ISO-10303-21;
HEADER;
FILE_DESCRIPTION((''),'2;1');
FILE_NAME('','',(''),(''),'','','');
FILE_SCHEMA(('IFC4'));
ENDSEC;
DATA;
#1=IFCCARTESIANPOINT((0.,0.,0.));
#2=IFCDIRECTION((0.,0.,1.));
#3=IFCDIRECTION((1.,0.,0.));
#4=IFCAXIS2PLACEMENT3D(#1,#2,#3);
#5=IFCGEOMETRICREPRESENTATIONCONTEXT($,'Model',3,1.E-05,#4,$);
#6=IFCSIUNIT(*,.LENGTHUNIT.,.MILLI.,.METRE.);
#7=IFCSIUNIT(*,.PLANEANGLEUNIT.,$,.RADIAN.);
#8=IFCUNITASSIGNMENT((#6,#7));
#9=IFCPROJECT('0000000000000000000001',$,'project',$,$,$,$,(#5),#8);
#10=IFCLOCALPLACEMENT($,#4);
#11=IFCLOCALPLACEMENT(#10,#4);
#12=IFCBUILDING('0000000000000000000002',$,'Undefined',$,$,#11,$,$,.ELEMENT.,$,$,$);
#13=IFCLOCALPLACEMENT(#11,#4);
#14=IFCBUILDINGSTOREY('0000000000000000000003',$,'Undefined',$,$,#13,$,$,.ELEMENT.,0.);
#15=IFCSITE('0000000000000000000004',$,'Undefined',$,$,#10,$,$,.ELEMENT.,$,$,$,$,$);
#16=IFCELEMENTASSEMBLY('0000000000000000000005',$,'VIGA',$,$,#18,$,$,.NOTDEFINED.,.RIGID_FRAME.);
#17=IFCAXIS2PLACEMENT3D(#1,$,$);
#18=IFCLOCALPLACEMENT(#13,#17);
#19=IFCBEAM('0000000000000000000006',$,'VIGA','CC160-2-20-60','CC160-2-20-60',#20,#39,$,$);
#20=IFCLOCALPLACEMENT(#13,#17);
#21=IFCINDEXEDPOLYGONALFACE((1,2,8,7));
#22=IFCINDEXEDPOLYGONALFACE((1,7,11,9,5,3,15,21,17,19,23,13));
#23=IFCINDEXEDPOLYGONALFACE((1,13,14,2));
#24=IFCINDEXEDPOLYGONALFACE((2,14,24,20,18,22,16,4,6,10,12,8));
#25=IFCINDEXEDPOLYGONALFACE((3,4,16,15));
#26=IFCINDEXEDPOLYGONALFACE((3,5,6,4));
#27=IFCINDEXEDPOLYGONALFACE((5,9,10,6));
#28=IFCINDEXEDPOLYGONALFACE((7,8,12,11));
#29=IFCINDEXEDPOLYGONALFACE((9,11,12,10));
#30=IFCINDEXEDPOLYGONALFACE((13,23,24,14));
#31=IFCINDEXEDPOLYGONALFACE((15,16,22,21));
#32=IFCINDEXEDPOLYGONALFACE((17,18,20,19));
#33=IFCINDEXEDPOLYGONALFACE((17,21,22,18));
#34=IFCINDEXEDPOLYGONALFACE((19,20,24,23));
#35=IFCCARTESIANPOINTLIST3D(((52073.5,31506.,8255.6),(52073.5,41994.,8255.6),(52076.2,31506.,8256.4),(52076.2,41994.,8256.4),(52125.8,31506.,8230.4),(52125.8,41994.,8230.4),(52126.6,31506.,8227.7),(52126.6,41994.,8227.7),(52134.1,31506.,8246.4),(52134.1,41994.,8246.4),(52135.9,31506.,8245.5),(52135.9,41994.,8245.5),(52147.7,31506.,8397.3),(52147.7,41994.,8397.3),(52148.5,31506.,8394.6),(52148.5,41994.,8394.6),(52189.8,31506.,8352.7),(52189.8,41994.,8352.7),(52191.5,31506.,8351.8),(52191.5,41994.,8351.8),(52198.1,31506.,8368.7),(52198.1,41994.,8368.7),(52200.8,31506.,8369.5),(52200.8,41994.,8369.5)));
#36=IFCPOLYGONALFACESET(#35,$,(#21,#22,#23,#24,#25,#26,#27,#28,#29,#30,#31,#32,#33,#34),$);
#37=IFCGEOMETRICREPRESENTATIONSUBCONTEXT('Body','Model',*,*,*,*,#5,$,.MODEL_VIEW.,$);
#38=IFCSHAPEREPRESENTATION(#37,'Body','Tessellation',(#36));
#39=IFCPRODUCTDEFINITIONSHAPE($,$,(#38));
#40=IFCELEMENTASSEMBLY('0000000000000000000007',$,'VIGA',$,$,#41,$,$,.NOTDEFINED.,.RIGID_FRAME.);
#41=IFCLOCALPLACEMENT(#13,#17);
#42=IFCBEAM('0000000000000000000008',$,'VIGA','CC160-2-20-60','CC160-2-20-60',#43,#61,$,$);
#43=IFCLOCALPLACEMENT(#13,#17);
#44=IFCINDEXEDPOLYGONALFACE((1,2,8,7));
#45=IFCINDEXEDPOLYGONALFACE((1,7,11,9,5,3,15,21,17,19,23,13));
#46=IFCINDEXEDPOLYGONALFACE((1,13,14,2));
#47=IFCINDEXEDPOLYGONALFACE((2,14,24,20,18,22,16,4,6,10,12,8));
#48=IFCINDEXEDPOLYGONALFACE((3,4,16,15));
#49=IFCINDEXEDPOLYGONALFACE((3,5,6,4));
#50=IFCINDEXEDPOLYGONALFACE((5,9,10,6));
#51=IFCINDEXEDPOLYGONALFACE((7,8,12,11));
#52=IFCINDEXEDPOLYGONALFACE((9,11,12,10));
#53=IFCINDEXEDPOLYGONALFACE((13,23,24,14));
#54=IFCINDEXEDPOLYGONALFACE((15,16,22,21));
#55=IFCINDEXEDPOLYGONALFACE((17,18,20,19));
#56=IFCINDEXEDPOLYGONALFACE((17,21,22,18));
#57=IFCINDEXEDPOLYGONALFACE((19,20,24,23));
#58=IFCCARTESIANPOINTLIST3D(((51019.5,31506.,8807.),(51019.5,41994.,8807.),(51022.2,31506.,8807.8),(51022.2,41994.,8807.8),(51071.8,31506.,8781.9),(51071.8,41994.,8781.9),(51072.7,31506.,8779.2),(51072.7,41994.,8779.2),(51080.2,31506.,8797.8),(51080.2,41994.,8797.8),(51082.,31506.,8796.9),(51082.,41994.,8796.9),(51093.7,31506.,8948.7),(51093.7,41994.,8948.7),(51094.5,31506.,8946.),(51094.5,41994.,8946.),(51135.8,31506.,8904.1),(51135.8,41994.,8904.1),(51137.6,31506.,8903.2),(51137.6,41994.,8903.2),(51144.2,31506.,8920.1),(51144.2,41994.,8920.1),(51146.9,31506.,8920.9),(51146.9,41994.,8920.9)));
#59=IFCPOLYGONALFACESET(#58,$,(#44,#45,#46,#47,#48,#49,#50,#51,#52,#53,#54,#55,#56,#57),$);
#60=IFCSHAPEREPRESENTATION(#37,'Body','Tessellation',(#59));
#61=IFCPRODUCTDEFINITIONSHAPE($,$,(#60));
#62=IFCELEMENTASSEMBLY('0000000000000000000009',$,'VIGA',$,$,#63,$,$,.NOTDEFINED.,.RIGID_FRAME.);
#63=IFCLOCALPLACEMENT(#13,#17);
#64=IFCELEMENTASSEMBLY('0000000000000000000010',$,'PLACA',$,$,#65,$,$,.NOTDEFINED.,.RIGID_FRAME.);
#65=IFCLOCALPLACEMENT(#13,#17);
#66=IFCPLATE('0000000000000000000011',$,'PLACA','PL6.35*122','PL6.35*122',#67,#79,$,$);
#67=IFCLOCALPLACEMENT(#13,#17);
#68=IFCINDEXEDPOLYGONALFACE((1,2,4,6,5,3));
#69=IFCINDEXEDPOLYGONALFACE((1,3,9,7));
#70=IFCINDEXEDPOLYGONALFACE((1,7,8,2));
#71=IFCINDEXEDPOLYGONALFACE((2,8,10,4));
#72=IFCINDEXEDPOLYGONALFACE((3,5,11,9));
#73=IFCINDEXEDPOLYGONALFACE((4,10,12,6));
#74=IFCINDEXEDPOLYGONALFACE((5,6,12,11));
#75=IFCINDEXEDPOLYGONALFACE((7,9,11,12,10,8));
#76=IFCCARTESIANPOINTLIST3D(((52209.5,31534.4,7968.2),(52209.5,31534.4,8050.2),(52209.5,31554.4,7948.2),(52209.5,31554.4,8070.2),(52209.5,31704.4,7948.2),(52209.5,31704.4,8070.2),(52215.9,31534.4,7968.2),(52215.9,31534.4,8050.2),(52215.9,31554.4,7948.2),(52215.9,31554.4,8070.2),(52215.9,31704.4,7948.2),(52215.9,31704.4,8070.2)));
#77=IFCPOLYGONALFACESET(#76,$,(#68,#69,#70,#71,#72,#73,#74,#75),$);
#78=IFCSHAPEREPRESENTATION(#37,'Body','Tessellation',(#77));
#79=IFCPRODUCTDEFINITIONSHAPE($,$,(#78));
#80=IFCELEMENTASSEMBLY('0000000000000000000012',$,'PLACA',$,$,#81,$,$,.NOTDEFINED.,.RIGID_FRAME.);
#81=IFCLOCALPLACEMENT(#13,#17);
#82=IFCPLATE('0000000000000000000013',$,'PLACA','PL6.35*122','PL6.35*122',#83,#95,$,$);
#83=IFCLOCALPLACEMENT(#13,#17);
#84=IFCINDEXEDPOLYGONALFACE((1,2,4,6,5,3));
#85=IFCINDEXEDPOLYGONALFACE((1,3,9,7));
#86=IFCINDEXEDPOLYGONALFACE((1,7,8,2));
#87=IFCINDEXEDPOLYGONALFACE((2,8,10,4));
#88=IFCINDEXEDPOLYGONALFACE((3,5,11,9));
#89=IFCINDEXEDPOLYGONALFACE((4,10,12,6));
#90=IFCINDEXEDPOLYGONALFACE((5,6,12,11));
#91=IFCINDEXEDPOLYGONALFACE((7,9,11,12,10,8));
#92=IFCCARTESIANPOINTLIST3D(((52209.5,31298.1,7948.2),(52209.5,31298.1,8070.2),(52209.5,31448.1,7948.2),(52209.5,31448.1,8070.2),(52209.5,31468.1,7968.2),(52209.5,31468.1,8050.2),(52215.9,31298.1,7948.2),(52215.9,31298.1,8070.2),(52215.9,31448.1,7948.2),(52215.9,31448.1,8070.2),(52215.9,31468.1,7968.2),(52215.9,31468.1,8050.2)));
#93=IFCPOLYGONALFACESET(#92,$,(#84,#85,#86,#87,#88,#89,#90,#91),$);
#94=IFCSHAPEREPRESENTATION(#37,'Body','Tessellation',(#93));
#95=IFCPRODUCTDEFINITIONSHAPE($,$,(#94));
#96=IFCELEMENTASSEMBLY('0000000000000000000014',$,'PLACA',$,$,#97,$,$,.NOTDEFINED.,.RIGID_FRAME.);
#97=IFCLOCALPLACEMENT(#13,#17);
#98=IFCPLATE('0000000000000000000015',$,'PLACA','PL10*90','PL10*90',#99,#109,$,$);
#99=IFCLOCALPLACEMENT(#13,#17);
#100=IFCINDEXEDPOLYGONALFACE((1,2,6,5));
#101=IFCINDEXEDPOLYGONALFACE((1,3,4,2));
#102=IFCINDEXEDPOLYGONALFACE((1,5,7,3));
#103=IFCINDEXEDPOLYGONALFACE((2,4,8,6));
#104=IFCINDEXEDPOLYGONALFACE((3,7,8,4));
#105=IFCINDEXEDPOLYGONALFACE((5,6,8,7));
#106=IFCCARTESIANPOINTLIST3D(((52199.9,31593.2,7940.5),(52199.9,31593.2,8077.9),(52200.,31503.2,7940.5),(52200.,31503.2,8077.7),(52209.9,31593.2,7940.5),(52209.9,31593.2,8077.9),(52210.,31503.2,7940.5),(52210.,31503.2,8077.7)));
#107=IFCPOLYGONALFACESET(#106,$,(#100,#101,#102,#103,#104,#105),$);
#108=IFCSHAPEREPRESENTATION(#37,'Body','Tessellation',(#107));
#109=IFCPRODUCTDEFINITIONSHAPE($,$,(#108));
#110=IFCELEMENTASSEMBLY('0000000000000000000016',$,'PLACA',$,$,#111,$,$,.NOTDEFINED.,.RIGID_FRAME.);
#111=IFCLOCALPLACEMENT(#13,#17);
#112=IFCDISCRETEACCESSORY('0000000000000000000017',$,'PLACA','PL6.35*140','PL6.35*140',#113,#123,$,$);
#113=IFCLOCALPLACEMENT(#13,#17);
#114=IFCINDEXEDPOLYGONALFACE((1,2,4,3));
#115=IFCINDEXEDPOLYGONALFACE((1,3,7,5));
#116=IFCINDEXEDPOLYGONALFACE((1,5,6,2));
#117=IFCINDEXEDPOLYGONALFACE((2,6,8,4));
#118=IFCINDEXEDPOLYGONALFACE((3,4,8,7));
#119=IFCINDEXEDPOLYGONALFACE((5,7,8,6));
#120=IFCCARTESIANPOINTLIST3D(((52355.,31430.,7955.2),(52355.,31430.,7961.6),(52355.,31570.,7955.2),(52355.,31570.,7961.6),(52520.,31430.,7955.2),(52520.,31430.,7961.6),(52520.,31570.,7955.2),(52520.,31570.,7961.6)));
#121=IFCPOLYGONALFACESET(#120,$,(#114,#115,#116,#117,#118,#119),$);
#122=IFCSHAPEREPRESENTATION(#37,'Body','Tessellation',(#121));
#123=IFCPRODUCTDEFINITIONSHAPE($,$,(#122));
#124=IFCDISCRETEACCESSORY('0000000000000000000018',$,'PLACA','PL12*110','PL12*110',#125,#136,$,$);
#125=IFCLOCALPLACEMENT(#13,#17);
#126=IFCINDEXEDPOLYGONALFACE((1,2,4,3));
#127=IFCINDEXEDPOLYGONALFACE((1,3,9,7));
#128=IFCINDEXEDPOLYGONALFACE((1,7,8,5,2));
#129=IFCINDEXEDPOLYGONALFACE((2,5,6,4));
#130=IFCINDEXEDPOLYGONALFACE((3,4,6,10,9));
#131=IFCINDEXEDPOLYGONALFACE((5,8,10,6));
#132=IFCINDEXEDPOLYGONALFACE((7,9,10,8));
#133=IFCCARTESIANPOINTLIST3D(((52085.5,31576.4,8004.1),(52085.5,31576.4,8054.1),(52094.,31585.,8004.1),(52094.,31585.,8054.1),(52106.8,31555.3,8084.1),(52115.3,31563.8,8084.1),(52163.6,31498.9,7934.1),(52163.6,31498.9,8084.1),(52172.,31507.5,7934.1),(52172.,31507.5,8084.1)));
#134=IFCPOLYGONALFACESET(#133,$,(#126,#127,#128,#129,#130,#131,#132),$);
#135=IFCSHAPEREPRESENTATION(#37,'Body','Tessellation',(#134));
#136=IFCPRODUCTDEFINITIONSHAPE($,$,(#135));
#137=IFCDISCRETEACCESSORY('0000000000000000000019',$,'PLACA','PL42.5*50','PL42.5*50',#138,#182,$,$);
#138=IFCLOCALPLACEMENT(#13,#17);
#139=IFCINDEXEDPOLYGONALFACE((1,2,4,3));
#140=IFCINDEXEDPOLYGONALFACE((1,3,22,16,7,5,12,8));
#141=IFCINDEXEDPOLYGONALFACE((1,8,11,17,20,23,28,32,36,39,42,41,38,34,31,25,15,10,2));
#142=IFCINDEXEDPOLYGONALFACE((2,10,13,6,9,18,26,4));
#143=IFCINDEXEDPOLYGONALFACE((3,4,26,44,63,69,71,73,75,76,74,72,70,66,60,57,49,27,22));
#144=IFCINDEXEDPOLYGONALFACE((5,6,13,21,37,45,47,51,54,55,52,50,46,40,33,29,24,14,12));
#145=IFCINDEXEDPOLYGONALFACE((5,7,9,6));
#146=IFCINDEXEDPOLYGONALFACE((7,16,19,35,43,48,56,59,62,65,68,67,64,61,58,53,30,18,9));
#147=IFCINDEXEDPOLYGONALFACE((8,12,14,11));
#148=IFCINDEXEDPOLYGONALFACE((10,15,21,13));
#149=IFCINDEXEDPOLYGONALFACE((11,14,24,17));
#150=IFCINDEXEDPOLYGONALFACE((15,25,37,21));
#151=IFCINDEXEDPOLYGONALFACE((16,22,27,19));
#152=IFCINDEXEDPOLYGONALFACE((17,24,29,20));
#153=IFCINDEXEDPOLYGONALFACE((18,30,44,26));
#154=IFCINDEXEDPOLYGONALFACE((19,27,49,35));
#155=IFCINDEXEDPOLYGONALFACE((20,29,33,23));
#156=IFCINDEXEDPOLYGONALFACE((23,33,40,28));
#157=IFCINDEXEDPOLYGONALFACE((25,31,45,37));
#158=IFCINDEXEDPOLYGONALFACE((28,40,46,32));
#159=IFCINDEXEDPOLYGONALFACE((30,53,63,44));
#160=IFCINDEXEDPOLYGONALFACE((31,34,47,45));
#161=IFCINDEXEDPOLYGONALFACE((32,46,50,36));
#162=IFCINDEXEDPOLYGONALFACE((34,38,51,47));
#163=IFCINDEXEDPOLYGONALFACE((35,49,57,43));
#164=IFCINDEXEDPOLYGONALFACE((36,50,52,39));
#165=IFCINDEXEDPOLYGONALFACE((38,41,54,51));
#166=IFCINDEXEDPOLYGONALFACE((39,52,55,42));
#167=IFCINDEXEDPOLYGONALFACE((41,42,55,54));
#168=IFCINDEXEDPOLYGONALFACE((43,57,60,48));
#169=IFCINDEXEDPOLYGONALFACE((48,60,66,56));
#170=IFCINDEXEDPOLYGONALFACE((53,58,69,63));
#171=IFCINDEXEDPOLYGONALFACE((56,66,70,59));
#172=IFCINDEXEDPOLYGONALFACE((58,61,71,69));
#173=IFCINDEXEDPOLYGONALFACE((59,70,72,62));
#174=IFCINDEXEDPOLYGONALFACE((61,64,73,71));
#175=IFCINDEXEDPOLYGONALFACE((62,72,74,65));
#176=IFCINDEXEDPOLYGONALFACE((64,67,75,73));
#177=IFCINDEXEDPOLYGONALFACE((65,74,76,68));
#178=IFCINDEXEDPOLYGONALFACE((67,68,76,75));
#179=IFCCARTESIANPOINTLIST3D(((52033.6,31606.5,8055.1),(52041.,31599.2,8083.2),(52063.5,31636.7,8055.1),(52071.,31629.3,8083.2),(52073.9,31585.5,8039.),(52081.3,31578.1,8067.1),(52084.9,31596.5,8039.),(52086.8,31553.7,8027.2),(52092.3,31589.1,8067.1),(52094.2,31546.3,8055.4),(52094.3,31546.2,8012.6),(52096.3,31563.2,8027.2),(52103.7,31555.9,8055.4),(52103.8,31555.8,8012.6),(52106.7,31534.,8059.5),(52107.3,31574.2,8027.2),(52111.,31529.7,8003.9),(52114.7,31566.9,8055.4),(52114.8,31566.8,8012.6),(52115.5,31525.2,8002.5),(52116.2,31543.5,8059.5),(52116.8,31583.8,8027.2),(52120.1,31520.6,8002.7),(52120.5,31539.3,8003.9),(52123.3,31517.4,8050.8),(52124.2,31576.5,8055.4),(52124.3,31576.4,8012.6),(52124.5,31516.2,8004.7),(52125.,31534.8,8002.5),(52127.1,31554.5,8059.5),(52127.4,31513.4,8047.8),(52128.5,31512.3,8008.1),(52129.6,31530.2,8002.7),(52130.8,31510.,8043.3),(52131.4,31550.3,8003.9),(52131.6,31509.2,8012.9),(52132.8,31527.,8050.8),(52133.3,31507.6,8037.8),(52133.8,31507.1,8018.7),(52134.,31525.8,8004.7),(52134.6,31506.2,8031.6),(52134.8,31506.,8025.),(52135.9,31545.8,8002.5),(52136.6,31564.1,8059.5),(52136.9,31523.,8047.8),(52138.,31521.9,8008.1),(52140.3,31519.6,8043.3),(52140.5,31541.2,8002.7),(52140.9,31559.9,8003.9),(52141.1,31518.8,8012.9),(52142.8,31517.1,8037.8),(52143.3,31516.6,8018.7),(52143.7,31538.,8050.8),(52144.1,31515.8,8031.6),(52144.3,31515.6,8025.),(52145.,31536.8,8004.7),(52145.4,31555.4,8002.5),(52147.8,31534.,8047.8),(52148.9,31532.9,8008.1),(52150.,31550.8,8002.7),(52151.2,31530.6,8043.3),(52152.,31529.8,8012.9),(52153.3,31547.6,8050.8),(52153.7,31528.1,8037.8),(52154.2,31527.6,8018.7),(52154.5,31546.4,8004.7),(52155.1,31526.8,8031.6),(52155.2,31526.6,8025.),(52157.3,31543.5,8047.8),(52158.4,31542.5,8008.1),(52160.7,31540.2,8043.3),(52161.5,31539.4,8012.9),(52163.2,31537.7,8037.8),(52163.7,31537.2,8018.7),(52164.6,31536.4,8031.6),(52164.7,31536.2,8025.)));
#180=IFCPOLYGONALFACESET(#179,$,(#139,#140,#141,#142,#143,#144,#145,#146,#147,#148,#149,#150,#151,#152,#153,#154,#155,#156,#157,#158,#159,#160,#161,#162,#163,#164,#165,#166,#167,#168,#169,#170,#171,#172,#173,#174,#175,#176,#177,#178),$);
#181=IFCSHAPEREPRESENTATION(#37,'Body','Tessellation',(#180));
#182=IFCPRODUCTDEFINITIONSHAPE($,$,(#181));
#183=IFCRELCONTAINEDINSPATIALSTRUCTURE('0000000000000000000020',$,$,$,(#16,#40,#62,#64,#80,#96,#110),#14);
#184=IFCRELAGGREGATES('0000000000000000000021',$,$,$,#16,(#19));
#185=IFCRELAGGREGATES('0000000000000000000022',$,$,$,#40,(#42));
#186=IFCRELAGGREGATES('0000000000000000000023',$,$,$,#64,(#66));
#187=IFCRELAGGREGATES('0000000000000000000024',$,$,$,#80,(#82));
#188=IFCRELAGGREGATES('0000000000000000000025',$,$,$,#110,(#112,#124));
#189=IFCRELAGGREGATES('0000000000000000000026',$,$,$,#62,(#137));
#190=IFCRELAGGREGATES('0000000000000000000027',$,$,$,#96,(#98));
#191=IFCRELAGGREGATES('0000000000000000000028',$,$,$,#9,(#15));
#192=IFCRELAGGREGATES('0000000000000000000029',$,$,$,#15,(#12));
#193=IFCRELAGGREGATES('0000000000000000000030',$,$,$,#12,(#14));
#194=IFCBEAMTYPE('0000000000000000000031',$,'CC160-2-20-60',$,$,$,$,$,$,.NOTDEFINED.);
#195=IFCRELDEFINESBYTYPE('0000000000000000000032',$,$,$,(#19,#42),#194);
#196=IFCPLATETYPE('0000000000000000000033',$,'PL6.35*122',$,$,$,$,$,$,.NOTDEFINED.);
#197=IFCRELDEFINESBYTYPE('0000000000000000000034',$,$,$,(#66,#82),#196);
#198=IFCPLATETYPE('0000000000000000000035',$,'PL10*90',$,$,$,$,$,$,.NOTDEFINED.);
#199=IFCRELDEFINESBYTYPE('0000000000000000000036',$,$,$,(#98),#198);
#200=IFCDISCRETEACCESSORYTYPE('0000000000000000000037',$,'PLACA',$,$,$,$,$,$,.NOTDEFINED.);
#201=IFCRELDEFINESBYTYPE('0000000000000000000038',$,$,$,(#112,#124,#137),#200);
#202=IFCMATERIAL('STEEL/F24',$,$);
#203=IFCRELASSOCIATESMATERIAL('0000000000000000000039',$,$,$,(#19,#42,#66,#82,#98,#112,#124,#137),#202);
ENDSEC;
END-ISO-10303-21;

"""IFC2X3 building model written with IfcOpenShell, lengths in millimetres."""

from ifc_helpers import new_model, si_unit, frame, origin_with_axes, origin_2d_with_axis, place, context, subcontext, project, spatial, polyline, rectangle, c_section, outline, extrude, boolean, clip, halfspace, material, type_object, element, aggregate, save


model = new_model("IFC2X3")

# Units and contexts
model_context = context("Model", 3, precision=1e-05, world=origin_with_axes())
body_context = subcontext(model_context, "Body", "Model", "MODEL_VIEW")
ifc_project = project(units=[si_unit("LENGTHUNIT", "METRE", prefix="MILLI"), si_unit("PLANEANGLEUNIT", "RADIAN")], contexts=[model_context])

# Site, building, storey
site_placement = place(None, origin_with_axes())
site = spatial("IfcSite", under=ifc_project, at=site_placement, Name="Undefined", CompositionType="ELEMENT")
building_placement = place(site_placement, origin_with_axes())
building = spatial("IfcBuilding", under=site, at=building_placement, Name="Undefined", CompositionType="ELEMENT")
storey_placement = place(building_placement, origin_with_axes())
storey = spatial("IfcBuildingStorey", under=building, at=storey_placement, Name="Undefined", CompositionType="ELEMENT", Elevation=0.0)

# Element assemblies, beams
ifc_material_1 = material(Name="STEEL/F24")
assembly_1_placement = place(storey_placement, origin_with_axes())
assembly_1 = element("IfcElementAssembly", 1, at=assembly_1_placement, inside=storey, Name="VIGA", AssemblyPlace="NOTDEFINED", PredefinedType="RIGID_FRAME")
beam_type_1 = type_object("IfcBeamType", Name="CC160-2-20-60", PredefinedType="NOTDEFINED")
beam_1_placement = place(assembly_1_placement, frame((52137.1, 31500.0, 8312.5), z_axis=(0.463605, 0.0, 0.886042), x_axis=(0.0, 1.0, 0.0)))
beam_1 = element("IfcBeam", 2, at=beam_1_placement, type_object=beam_type_1, material=ifc_material_1, Name="VIGA", Description="CC160-2-20-60", ObjectType="CC160-2-20-60", context=body_context, shape_type="Clipping", body=[
    clip(clip(extrude(c_section(Depth=160.0, Width=60.0, WallThickness=2.0, Girth=20.0, at=origin_2d_with_axis()), frame((10500.0, 0.0, 0.0), z_axis=(-1.0, 0.0, 0.0), x_axis=(0.0, -1.0, 0.0)), (0.0, 0.0, 1.0), 10500.0), halfspace(frame((10494.0, 30.0, 80.0), z_axis=(1.0, 0.0, 0.000029), x_axis=(0.000029, 0.0, -1.0)), False)), halfspace(frame((6.0, -30.0, 80.0), z_axis=(-1.0, 0.0, -0.000029), x_axis=(0.000029, 0.0, -1.0)), False)),
])
aggregate(assembly_1, [beam_1])
assembly_2_placement = place(storey_placement, origin_with_axes())
assembly_2 = element("IfcElementAssembly", 3, at=assembly_2_placement, inside=storey, Name="VIGA", AssemblyPlace="NOTDEFINED", PredefinedType="RIGID_FRAME")
beam_2_placement = place(assembly_2_placement, frame((51083.2, 31500.0, 8864.0), z_axis=(0.463605, 0.0, 0.886042), x_axis=(0.0, 1.0, 0.0)))
beam_2 = element("IfcBeam", 4, at=beam_2_placement, type_object=beam_type_1, material=ifc_material_1, Name="VIGA", Description="CC160-2-20-60", ObjectType="CC160-2-20-60", context=body_context, shape_type="Clipping", body=[
    clip(clip(extrude(c_section(Depth=160.0, Width=60.0, WallThickness=2.0, Girth=20.0, at=origin_2d_with_axis()), frame((10500.0, 0.0, 0.0), z_axis=(-1.0, 0.0, 0.0), x_axis=(0.0, -1.0, 0.0)), (0.0, 0.0, 1.0), 10500.0), halfspace(frame((10494.0, 30.0, 80.0), z_axis=(1.0, 0.0, 0.000029), x_axis=(0.000029, 0.0, -1.0)), False)), halfspace(frame((6.0, -30.0, 80.0), z_axis=(-1.0, 0.0, -0.000029), x_axis=(0.000029, 0.0, -1.0)), False)),
])
aggregate(assembly_2, [beam_2])
assembly_3_placement = place(storey_placement, origin_with_axes())
assembly_3 = element("IfcElementAssembly", 5, at=assembly_3_placement, inside=storey, Name="VIGA", AssemblyPlace="NOTDEFINED", PredefinedType="RIGID_FRAME")

# Element assemblies, plates
assembly_4_placement = place(storey_placement, origin_with_axes())
assembly_4 = element("IfcElementAssembly", 6, at=assembly_4_placement, inside=storey, Name="PLACA", AssemblyPlace="NOTDEFINED", PredefinedType="RIGID_FRAME")
plate_type_1 = type_object("IfcPlateType", Name="PL6.35*122", PredefinedType="NOTDEFINED")
plate_1_placement = place(assembly_4_placement, frame((52212.7, 31534.4, 8070.2), z_axis=(-1.0, 0.0, 0.0), x_axis=(0.0, 1.0, 0.0)))
plate_1 = element("IfcPlate", 7, at=plate_1_placement, type_object=plate_type_1, material=ifc_material_1, Name="PLACA", Description="PL6.35*122", ObjectType="PL6.35*122", context=body_context, shape_type="SweptSolid", body=[
    extrude(outline(polyline([(0.0, 20.0), (20.0, 0.0), (170.0, 0.0), (170.0, 122.0), (20.0, 122.0), (0.0, 102.0), (0.0, 20.0)])), frame((0.0, 0.0, -3.2), z_axis=(0.0, 0.0, 1.0), x_axis=(1.0, 0.0, 0.0)), (0.0, 0.0, 1.0), 6.4),
])
aggregate(assembly_4, [plate_1])
assembly_5_placement = place(storey_placement, origin_with_axes())
assembly_5 = element("IfcElementAssembly", 8, at=assembly_5_placement, inside=storey, Name="PLACA", AssemblyPlace="NOTDEFINED", PredefinedType="RIGID_FRAME")
plate_2_placement = place(assembly_5_placement, frame((52212.7, 31468.1, 8070.2), z_axis=(1.0, 0.0, 0.0), x_axis=(0.0, -1.0, 0.0)))
plate_2 = element("IfcPlate", 9, at=plate_2_placement, type_object=plate_type_1, material=ifc_material_1, Name="PLACA", Description="PL6.35*122", ObjectType="PL6.35*122", context=body_context, shape_type="SweptSolid", body=[
    extrude(outline(polyline([(0.0, 20.0), (20.0, 0.0), (170.0, 0.0), (170.0, 122.0), (20.0, 122.0), (0.0, 102.0), (0.0, 20.0)])), frame((0.0, 0.0, -3.2), z_axis=(0.0, 0.0, 1.0), x_axis=(1.0, 0.0, 0.0)), (0.0, 0.0, 1.0), 6.4),
])
aggregate(assembly_5, [plate_2])
assembly_6_placement = place(storey_placement, origin_with_axes())
assembly_6 = element("IfcElementAssembly", 10, at=assembly_6_placement, inside=storey, Name="PLACA", AssemblyPlace="NOTDEFINED", PredefinedType="RIGID_FRAME")
plate_type_2 = type_object("IfcPlateType", Name="PL10*90", PredefinedType="NOTDEFINED")
plate_3_placement = place(assembly_6_placement, frame((52204.9, 31593.2, 7940.5), z_axis=(-1.0, -0.000594, -0.000001), x_axis=(0.000594, -1.0, 0.000002)))
plate_3 = element("IfcPlate", 11, at=plate_3_placement, type_object=plate_type_2, material=ifc_material_1, Name="PLACA", Description="PL10*90", ObjectType="PL10*90", context=body_context, shape_type="SweptSolid", body=[
    extrude(outline(polyline([(0.0, 0.0), (90.0, 0.0), (90.0, 137.1), (0.0, 137.4), (0.0, 0.0)])), frame((0.0, 0.0, -5.0), z_axis=(0.0, 0.0, 1.0), x_axis=(1.0, 0.0, 0.0)), (0.0, 0.0, 1.0), 10.0),
])

# Element assembly, discrete accessories
assembly_7_placement = place(storey_placement, origin_with_axes())
assembly_7 = element("IfcElementAssembly", 12, at=assembly_7_placement, inside=storey, Name="PLACA", AssemblyPlace="NOTDEFINED", PredefinedType="RIGID_FRAME")
discrete_accessory_type_1 = type_object("IfcDiscreteAccessoryType", Name="PLACA")
discrete_accessory_1_placement = place(assembly_7_placement, frame((52520.0, 31570.0, 7958.4), z_axis=(0.0, 0.0, -1.0), x_axis=(0.0, -1.0, 0.0)))
discrete_accessory_1 = element("IfcDiscreteAccessory", 13, at=discrete_accessory_1_placement, type_object=discrete_accessory_type_1, material=ifc_material_1, Name="PLACA", Description="PL6.35*140", ObjectType="PL6.35*140", context=body_context, shape_type="SweptSolid", body=[
    extrude(outline(polyline([(0.0, 0.0), (140.0, 0.0), (140.0, 165.0), (0.0, 165.0), (0.0, 0.0)])), frame((0.0, 0.0, -3.2), z_axis=(0.0, 0.0, 1.0), x_axis=(1.0, 0.0, 0.0)), (0.0, 0.0, 1.0), 6.4),
])
discrete_accessory_2_placement = place(assembly_7_placement, frame((52111.0, 31559.6, 8084.1), z_axis=(0.704562, 0.709643, 0.0), x_axis=(0.709643, -0.704562, 0.0)))
discrete_accessory_2 = element("IfcDiscreteAccessory", 14, at=discrete_accessory_2_placement, type_object=discrete_accessory_type_1, material=ifc_material_1, Name="PLACA", Description="PL12*110", ObjectType="PL12*110", context=body_context, shape_type="SweptSolid", body=[
    extrude(outline(polyline([(0.0, 0.0), (80.0, 0.0), (80.0, 150.0), (-30.0, 80.0), (-30.0, 30.0), (0.0, 0.0)])), frame((0.0, 0.0, -6.0), z_axis=(0.0, 0.0, 1.0), x_axis=(1.0, 0.0, 0.0)), (0.0, 0.0, 1.0), 12.0),
])

# Discrete accessory
discrete_accessory_3_placement = place(assembly_3_placement, frame((52154.9, 31516.0, 8042.1), z_axis=(0.704562, 0.709643, 0.0), x_axis=(-0.247001, 0.245233, -0.937471)))
discrete_accessory_3 = element("IfcDiscreteAccessory", 15, at=discrete_accessory_3_placement, type_object=discrete_accessory_type_1, material=ifc_material_1, Name="PLACA", Description="PL42.5*50", ObjectType="PL42.5*50", context=body_context, shape_type="CSG", body=[
    boolean("DIFFERENCE", extrude(outline(polyline([(0.0, 25.0), (0.9, 18.5), (3.3, 12.5), (7.3, 7.3), (12.5, 3.3), (18.5, 0.9), (25.0, 0.0), (25.0, 0.0), (31.5, 0.9), (37.5, 3.3), (42.7, 7.3), (46.7, 12.5), (49.1, 18.5), (50.0, 25.0), (50.0, 50.0), (40.0, 65.0), (40.0, 145.0), (10.0, 145.0), (10.0, 65.0), (0.0, 50.0), (0.0, 25.0)])), frame((0.0, 0.0, -21.2), z_axis=(0.0, 0.0, 1.0), x_axis=(1.0, 0.0, 0.0)), (0.0, 0.0, 1.0), 42.5), extrude(rectangle(XDim=15.5, YDim=60.0, at=origin_2d_with_axis()), frame((25.0, 98.7, 0.0), z_axis=(0.0, -1.0, 0.0), x_axis=(0.0, 0.0, -1.0)), (0.0, 0.0, 1.0), 108.7)),
])

aggregate(assembly_7, [discrete_accessory_1, discrete_accessory_2])
aggregate(assembly_3, [discrete_accessory_3])
aggregate(assembly_6, [plate_3])

save(model, "model.ifc")
